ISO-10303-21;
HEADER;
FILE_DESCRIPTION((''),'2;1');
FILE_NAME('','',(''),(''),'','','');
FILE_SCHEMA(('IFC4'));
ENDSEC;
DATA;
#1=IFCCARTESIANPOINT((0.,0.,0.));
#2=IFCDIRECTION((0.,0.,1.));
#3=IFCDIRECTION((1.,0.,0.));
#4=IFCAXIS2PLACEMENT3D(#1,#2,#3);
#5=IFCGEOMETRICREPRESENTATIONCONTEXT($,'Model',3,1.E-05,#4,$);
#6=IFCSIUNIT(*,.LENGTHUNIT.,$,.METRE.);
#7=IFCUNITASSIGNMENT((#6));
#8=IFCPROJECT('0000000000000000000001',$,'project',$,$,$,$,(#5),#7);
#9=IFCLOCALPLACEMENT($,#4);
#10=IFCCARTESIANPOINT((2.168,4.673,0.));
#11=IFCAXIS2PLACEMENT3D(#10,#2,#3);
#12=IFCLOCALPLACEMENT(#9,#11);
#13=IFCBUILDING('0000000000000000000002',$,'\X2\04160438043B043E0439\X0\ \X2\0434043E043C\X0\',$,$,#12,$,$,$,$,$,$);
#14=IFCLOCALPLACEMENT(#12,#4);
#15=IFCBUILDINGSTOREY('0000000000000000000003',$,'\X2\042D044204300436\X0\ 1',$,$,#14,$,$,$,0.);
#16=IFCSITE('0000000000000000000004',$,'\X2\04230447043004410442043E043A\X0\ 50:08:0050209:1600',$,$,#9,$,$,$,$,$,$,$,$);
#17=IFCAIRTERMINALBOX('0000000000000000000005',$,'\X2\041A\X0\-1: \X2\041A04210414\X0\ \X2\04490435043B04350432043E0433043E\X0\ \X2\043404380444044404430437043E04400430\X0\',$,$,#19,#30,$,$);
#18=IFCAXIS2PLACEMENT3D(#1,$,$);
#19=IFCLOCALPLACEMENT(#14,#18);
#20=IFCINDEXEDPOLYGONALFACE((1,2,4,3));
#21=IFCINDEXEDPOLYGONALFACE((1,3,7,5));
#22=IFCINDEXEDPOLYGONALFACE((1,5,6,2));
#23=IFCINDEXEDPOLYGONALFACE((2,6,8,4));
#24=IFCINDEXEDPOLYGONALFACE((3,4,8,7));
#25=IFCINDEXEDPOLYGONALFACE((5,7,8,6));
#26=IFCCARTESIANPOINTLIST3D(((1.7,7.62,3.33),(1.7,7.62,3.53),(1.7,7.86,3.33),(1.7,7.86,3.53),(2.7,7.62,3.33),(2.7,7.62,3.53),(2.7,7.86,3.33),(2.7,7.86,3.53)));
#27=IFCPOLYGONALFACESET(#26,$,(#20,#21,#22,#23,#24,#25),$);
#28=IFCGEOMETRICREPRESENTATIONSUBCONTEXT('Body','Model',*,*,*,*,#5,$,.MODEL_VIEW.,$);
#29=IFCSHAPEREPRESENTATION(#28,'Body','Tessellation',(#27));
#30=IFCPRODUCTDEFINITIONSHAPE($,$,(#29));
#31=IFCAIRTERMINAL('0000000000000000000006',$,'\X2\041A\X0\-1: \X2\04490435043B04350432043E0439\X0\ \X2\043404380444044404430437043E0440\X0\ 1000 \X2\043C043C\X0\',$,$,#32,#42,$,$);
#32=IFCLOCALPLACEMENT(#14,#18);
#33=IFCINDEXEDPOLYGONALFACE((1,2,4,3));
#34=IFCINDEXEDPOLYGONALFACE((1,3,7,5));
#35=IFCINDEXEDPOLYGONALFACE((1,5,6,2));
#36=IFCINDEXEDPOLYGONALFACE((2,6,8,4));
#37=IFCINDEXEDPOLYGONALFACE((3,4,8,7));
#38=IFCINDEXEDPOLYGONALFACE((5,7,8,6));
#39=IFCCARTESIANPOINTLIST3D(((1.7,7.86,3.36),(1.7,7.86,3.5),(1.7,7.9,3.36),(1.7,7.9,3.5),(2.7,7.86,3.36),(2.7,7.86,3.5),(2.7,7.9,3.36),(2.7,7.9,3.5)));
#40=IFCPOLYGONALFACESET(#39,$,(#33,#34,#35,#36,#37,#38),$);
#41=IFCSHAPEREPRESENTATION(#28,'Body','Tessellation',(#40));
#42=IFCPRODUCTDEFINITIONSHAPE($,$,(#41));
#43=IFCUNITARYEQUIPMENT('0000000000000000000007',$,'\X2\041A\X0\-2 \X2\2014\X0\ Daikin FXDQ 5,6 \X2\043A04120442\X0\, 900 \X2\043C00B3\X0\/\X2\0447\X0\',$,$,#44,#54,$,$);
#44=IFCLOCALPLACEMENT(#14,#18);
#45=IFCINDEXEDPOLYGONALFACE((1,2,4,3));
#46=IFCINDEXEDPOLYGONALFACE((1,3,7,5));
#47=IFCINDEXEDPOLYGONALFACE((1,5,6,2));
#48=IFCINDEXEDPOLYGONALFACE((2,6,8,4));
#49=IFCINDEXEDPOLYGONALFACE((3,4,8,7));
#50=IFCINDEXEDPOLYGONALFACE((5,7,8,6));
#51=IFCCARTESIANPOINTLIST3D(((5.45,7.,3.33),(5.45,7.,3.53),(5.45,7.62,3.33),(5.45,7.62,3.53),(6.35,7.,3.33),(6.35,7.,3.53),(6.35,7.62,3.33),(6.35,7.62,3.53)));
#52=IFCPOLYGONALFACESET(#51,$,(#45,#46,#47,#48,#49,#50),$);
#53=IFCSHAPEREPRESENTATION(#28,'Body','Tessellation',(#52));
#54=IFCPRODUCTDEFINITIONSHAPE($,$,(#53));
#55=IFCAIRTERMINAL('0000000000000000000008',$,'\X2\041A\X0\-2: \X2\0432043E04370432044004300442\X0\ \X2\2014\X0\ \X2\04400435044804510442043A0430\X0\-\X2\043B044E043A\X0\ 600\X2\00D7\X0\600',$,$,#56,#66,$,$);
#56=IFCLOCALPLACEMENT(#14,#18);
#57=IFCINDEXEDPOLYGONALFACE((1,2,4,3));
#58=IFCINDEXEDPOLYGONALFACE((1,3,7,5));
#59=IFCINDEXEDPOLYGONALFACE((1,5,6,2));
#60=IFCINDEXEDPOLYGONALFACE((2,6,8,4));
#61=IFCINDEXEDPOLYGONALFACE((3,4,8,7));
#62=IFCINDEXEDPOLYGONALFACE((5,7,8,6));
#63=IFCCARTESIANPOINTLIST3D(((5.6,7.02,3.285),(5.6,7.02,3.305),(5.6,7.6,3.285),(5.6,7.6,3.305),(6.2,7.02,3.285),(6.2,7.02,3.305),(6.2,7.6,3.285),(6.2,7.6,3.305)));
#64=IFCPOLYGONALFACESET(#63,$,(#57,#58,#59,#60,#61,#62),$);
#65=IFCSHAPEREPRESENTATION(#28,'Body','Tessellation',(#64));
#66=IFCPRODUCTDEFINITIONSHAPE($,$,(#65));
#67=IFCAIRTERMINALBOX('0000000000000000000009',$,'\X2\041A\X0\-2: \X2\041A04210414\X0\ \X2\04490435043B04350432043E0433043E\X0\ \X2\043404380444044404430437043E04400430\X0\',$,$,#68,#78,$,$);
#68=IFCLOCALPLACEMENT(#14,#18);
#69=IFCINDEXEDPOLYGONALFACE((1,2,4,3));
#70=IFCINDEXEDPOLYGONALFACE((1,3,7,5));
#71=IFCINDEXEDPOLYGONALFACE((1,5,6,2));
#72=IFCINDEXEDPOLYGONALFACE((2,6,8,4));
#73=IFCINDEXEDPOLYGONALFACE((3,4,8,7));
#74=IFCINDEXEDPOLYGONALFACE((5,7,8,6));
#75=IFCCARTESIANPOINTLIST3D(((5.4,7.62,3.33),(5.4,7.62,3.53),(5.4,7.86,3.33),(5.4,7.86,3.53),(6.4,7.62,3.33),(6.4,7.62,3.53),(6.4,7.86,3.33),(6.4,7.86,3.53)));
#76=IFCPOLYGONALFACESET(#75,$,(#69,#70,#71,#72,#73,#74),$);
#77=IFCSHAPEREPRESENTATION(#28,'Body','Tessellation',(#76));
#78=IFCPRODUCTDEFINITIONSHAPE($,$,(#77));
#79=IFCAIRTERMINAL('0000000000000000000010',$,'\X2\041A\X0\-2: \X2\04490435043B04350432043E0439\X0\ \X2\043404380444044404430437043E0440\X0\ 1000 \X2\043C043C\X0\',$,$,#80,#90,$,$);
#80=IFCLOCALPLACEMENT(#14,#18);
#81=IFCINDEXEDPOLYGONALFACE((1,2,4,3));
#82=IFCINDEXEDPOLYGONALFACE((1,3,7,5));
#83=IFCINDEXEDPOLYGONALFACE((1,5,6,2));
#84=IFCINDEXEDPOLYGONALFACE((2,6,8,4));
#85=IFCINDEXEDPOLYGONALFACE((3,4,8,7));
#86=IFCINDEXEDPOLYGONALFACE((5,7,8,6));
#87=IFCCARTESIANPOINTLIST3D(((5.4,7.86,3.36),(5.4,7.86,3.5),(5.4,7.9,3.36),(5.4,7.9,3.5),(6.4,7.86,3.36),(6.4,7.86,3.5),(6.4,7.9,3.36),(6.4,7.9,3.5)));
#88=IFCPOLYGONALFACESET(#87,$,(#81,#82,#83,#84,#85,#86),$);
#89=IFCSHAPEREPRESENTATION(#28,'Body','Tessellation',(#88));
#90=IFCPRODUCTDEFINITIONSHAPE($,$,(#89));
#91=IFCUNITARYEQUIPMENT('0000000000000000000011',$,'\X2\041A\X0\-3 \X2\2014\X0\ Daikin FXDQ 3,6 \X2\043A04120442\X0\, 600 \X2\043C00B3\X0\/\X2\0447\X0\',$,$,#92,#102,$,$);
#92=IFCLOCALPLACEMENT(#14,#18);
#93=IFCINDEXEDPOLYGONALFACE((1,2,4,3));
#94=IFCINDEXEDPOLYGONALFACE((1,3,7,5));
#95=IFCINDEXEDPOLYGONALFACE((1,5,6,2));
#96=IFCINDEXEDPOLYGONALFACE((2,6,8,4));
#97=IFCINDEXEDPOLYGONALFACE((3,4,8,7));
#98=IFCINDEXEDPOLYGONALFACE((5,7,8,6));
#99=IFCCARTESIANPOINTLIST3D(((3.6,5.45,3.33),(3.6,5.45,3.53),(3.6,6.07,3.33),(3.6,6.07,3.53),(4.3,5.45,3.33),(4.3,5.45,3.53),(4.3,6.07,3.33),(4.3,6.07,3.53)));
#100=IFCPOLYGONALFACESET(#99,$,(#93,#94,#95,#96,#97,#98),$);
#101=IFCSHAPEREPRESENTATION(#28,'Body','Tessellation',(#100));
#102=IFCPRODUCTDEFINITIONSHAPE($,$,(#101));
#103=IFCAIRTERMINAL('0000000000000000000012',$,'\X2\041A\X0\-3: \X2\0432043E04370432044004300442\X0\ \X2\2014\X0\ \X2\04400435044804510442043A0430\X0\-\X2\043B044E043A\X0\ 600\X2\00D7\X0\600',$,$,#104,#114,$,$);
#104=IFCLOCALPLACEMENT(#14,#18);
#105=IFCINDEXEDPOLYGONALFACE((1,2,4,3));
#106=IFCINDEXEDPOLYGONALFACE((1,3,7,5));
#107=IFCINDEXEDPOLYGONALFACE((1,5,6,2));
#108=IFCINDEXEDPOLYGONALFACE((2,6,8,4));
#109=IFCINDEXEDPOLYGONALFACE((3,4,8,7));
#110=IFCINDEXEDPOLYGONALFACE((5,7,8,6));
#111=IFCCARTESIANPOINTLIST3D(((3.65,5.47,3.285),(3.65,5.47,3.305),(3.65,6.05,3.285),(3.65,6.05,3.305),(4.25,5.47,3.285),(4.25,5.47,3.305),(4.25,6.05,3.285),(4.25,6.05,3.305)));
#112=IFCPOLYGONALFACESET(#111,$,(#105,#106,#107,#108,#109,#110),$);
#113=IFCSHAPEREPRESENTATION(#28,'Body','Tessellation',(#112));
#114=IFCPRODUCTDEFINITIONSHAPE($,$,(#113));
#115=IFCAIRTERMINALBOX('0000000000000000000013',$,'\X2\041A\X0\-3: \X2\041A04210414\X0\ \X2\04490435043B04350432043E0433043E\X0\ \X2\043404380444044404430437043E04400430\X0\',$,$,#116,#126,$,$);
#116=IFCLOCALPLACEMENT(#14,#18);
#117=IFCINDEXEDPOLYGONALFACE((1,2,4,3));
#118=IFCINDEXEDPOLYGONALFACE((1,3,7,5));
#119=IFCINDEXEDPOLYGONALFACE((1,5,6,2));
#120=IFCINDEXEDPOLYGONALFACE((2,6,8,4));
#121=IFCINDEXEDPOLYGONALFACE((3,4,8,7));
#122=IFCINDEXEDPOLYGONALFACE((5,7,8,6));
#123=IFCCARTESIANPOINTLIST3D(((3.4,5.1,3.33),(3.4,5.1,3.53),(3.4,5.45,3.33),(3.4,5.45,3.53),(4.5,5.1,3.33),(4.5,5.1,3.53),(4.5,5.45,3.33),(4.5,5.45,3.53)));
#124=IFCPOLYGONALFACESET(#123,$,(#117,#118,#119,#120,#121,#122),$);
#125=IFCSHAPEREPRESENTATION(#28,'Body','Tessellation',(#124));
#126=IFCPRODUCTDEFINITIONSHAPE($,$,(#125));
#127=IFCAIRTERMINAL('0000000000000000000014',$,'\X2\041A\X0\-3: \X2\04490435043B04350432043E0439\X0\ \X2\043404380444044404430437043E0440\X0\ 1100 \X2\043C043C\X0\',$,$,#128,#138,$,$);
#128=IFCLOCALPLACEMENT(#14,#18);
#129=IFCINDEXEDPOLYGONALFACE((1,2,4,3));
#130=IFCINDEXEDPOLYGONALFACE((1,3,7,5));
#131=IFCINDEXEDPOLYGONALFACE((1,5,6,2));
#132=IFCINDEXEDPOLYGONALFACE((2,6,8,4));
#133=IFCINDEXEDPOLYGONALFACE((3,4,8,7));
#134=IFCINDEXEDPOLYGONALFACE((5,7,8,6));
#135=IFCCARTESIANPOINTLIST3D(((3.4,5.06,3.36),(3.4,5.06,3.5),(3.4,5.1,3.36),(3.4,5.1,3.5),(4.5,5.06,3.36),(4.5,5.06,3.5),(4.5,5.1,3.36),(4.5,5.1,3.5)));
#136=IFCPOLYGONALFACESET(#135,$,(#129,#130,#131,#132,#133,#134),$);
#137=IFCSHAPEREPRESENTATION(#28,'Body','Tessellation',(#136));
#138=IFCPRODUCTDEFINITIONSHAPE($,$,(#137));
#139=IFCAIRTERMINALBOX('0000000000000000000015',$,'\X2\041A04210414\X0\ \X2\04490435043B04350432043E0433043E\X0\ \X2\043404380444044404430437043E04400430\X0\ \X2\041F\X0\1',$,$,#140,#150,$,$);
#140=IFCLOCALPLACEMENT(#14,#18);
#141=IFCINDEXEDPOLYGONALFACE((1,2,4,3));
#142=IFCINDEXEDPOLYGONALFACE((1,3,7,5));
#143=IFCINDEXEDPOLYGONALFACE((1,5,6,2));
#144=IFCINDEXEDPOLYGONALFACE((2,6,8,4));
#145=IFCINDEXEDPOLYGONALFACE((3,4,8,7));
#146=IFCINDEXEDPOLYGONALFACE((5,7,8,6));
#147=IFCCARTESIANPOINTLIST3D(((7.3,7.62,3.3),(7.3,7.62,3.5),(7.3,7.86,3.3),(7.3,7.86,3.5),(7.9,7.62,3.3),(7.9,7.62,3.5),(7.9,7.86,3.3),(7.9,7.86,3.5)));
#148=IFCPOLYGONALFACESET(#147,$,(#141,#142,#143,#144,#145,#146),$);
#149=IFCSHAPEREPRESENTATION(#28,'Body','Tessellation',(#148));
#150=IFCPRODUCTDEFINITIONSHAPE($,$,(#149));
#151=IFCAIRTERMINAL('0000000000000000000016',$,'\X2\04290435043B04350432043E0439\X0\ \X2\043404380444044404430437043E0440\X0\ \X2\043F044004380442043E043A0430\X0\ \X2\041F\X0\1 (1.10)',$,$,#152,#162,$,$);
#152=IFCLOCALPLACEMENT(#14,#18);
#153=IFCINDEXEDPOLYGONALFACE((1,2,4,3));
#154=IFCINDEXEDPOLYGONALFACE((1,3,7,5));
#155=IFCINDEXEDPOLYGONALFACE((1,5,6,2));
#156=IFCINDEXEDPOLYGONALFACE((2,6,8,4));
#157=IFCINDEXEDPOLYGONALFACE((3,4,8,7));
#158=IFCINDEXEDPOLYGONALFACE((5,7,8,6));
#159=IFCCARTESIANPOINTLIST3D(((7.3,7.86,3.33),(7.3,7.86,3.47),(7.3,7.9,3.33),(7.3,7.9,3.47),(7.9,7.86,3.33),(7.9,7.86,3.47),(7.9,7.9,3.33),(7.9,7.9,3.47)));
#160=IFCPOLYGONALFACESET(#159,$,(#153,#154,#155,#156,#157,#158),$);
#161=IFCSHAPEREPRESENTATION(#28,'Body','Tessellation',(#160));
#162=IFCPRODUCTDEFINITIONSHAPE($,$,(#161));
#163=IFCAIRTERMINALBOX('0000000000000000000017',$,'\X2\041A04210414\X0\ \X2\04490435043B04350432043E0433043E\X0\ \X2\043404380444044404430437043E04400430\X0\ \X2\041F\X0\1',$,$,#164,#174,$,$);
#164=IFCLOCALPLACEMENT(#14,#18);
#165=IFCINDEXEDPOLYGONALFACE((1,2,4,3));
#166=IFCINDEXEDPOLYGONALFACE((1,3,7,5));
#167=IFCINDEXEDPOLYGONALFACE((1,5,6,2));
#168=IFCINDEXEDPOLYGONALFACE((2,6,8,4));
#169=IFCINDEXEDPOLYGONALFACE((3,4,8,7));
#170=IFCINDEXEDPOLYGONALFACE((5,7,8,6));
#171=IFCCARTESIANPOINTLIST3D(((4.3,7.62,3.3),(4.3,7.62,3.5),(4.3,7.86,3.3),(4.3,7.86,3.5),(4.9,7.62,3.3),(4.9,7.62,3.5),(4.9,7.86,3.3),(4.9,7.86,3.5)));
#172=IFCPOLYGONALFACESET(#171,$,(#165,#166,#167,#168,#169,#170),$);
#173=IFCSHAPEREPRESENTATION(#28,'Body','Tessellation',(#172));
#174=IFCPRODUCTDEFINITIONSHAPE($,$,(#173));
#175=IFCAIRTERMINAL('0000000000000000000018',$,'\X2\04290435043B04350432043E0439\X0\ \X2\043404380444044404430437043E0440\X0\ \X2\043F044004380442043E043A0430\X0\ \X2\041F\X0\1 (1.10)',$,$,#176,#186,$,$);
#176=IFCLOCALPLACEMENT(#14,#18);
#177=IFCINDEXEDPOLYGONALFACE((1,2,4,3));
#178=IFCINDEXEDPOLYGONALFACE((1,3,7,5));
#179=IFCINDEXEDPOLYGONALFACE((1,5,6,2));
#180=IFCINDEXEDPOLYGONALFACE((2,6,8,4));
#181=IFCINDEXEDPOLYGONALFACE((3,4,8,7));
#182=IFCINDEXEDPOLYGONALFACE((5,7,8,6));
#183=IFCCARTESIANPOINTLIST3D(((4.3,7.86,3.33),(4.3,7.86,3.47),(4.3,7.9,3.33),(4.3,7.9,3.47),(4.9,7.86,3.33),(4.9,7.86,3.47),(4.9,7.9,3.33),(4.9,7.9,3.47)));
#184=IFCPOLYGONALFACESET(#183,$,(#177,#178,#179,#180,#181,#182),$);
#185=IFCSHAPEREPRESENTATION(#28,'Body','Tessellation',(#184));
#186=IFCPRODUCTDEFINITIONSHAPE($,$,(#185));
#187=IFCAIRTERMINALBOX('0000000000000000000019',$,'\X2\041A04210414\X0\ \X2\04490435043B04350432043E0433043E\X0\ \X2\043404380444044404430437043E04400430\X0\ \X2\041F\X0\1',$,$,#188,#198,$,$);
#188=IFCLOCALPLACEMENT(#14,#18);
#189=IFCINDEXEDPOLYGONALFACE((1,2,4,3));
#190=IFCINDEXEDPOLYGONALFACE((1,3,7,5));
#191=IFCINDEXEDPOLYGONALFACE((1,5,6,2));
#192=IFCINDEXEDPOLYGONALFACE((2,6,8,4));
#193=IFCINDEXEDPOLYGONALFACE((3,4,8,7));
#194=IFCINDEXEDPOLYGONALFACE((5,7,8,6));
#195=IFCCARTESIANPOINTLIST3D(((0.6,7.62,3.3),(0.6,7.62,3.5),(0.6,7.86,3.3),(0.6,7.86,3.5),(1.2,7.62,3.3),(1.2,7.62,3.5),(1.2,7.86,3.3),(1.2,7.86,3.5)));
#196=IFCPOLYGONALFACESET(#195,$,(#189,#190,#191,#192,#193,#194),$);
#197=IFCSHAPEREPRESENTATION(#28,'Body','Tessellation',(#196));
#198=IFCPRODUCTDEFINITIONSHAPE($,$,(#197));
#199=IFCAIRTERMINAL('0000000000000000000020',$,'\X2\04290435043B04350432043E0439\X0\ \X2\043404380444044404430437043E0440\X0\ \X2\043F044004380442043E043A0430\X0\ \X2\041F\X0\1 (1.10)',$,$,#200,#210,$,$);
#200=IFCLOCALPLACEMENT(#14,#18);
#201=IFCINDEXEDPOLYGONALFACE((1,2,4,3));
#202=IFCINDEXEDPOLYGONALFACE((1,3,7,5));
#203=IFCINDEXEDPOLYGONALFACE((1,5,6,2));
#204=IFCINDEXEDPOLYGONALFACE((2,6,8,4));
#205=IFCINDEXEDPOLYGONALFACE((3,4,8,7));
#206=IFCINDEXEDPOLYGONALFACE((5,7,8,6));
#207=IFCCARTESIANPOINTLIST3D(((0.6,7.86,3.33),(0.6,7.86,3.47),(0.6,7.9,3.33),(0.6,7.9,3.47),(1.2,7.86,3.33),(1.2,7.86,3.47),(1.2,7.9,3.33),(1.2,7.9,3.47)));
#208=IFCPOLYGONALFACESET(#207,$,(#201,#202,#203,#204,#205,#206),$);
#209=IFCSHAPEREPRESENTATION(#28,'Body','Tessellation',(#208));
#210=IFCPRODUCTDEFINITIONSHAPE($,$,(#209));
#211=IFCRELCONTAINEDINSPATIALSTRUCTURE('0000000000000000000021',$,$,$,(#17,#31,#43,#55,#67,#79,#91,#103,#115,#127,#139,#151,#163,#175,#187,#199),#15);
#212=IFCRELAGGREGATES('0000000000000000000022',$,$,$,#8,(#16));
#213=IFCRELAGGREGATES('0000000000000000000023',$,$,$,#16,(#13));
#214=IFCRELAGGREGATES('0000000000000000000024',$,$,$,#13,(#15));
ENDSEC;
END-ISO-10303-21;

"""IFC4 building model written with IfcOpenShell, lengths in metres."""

from ifc_helpers import new_model, si_unit, frame, frame_2d, origin_with_axes, place, context, subcontext, project, spatial, rectangle, extrude, element, save


model = new_model("IFC4")

# Units and contexts
model_context = context("Model", 3, precision=1e-05, world=origin_with_axes())
body_context = subcontext(model_context, "Body", "Model", "MODEL_VIEW")
ifc_project = project(units=[si_unit("LENGTHUNIT", "METRE")], contexts=[model_context])

# Site, building, storey
site_placement = place(None, origin_with_axes())
site = spatial("IfcSite", under=ifc_project, at=site_placement, Name="Участок 50:08:0050209:1600")
building_placement = place(site_placement, frame((2.168, 4.673, 0.0), z_axis=(0.0, 0.0, 1.0), x_axis=(1.0, 0.0, 0.0)))
building = spatial("IfcBuilding", under=site, at=building_placement, Name="Жилой дом")
storey_placement = place(building_placement, origin_with_axes())
storey = spatial("IfcBuildingStorey", under=building, at=storey_placement, Name="Этаж 1", Elevation=0.0)

# Air terminal box
air_terminal_box_1_placement = place(storey_placement, origin_with_axes())
element("IfcAirTerminalBox", 1, at=air_terminal_box_1_placement, inside=storey, Name="К-1: КСД щелевого диффузора", context=body_context, shape_type="SweptSolid", body=[
    extrude(rectangle(XDim=1.0, YDim=0.24, at=frame_2d((0.5, 0.12))), frame((1.7, 7.62, 3.33), z_axis=(0.0, 0.0, 1.0), x_axis=(1.0, 0.0, 0.0)), (0.0, 0.0, 1.0), 0.2),
])

# Air terminal
air_terminal_1_placement = place(storey_placement, origin_with_axes())
element("IfcAirTerminal", 2, at=air_terminal_1_placement, inside=storey, Name="К-1: щелевой диффузор 1000 мм", context=body_context, shape_type="SweptSolid", body=[
    extrude(rectangle(XDim=1.0, YDim=0.04, at=frame_2d((0.5, 0.02))), frame((1.7, 7.86, 3.36), z_axis=(0.0, 0.0, 1.0), x_axis=(1.0, 0.0, 0.0)), (0.0, 0.0, 1.0), 0.14),
])

# Unitary equipment
unitary_equipment_1_placement = place(storey_placement, origin_with_axes())
element("IfcUnitaryEquipment", 3, at=unitary_equipment_1_placement, inside=storey, Name="К-2 — Daikin FXDQ 5,6 кВт, 900 м³/ч", context=body_context, shape_type="SweptSolid", body=[
    extrude(rectangle(XDim=0.9, YDim=0.62, at=frame_2d((0.45, 0.31))), frame((5.45, 7.0, 3.33), z_axis=(0.0, 0.0, 1.0), x_axis=(1.0, 0.0, 0.0)), (0.0, 0.0, 1.0), 0.2),
])

# Air terminal
air_terminal_2_placement = place(storey_placement, origin_with_axes())
element("IfcAirTerminal", 4, at=air_terminal_2_placement, inside=storey, Name="К-2: возврат — решётка-люк 600×600", context=body_context, shape_type="SweptSolid", body=[
    extrude(rectangle(XDim=0.6, YDim=0.58, at=frame_2d((0.3, 0.29))), frame((5.6, 7.02, 3.285), z_axis=(0.0, 0.0, 1.0), x_axis=(1.0, 0.0, 0.0)), (0.0, 0.0, 1.0), 0.02),
])

# Air terminal box
air_terminal_box_2_placement = place(storey_placement, origin_with_axes())
element("IfcAirTerminalBox", 5, at=air_terminal_box_2_placement, inside=storey, Name="К-2: КСД щелевого диффузора", context=body_context, shape_type="SweptSolid", body=[
    extrude(rectangle(XDim=1.0, YDim=0.24, at=frame_2d((0.5, 0.12))), frame((5.4, 7.62, 3.33), z_axis=(0.0, 0.0, 1.0), x_axis=(1.0, 0.0, 0.0)), (0.0, 0.0, 1.0), 0.2),
])

# Air terminal
air_terminal_3_placement = place(storey_placement, origin_with_axes())
element("IfcAirTerminal", 6, at=air_terminal_3_placement, inside=storey, Name="К-2: щелевой диффузор 1000 мм", context=body_context, shape_type="SweptSolid", body=[
    extrude(rectangle(XDim=1.0, YDim=0.04, at=frame_2d((0.5, 0.02))), frame((5.4, 7.86, 3.36), z_axis=(0.0, 0.0, 1.0), x_axis=(1.0, 0.0, 0.0)), (0.0, 0.0, 1.0), 0.14),
])

# Unitary equipment
unitary_equipment_2_placement = place(storey_placement, origin_with_axes())
element("IfcUnitaryEquipment", 7, at=unitary_equipment_2_placement, inside=storey, Name="К-3 — Daikin FXDQ 3,6 кВт, 600 м³/ч", context=body_context, shape_type="SweptSolid", body=[
    extrude(rectangle(XDim=0.7, YDim=0.62, at=frame_2d((0.35, 0.31))), frame((3.6, 5.45, 3.33), z_axis=(0.0, 0.0, 1.0), x_axis=(1.0, 0.0, 0.0)), (0.0, 0.0, 1.0), 0.2),
])

# Air terminal
air_terminal_4_placement = place(storey_placement, origin_with_axes())
element("IfcAirTerminal", 8, at=air_terminal_4_placement, inside=storey, Name="К-3: возврат — решётка-люк 600×600", context=body_context, shape_type="SweptSolid", body=[
    extrude(rectangle(XDim=0.6, YDim=0.58, at=frame_2d((0.3, 0.29))), frame((3.65, 5.47, 3.285), z_axis=(0.0, 0.0, 1.0), x_axis=(1.0, 0.0, 0.0)), (0.0, 0.0, 1.0), 0.02),
])

# Air terminal box
air_terminal_box_3_placement = place(storey_placement, origin_with_axes())
element("IfcAirTerminalBox", 9, at=air_terminal_box_3_placement, inside=storey, Name="К-3: КСД щелевого диффузора", context=body_context, shape_type="SweptSolid", body=[
    extrude(rectangle(XDim=1.1, YDim=0.35, at=frame_2d((0.55, 0.175))), frame((3.4, 5.1, 3.33), z_axis=(0.0, 0.0, 1.0), x_axis=(1.0, 0.0, 0.0)), (0.0, 0.0, 1.0), 0.2),
])

# Air terminal
air_terminal_5_placement = place(storey_placement, origin_with_axes())
element("IfcAirTerminal", 10, at=air_terminal_5_placement, inside=storey, Name="К-3: щелевой диффузор 1100 мм", context=body_context, shape_type="SweptSolid", body=[
    extrude(rectangle(XDim=1.1, YDim=0.04, at=frame_2d((0.55, 0.02))), frame((3.4, 5.06, 3.36), z_axis=(0.0, 0.0, 1.0), x_axis=(1.0, 0.0, 0.0)), (0.0, 0.0, 1.0), 0.14),
])

# Air terminal box
air_terminal_box_4_placement = place(storey_placement, origin_with_axes())
element("IfcAirTerminalBox", 11, at=air_terminal_box_4_placement, inside=storey, Name="КСД щелевого диффузора П1", context=body_context, shape_type="SweptSolid", body=[
    extrude(rectangle(XDim=0.6, YDim=0.24, at=frame_2d((0.3, 0.12))), frame((7.3, 7.62, 3.3), z_axis=(0.0, 0.0, 1.0), x_axis=(1.0, 0.0, 0.0)), (0.0, 0.0, 1.0), 0.2),
])

# Air terminal
air_terminal_6_placement = place(storey_placement, origin_with_axes())
element("IfcAirTerminal", 12, at=air_terminal_6_placement, inside=storey, Name="Щелевой диффузор притока П1 (1.10)", context=body_context, shape_type="SweptSolid", body=[
    extrude(rectangle(XDim=0.6, YDim=0.04, at=frame_2d((0.3, 0.02))), frame((7.3, 7.86, 3.33), z_axis=(0.0, 0.0, 1.0), x_axis=(1.0, 0.0, 0.0)), (0.0, 0.0, 1.0), 0.14),
])

# Air terminal box
air_terminal_box_5_placement = place(storey_placement, origin_with_axes())
element("IfcAirTerminalBox", 13, at=air_terminal_box_5_placement, inside=storey, Name="КСД щелевого диффузора П1", context=body_context, shape_type="SweptSolid", body=[
    extrude(rectangle(XDim=0.6, YDim=0.24, at=frame_2d((0.3, 0.12))), frame((4.3, 7.62, 3.3), z_axis=(0.0, 0.0, 1.0), x_axis=(1.0, 0.0, 0.0)), (0.0, 0.0, 1.0), 0.2),
])

# Air terminal
air_terminal_7_placement = place(storey_placement, origin_with_axes())
element("IfcAirTerminal", 14, at=air_terminal_7_placement, inside=storey, Name="Щелевой диффузор притока П1 (1.10)", context=body_context, shape_type="SweptSolid", body=[
    extrude(rectangle(XDim=0.6, YDim=0.04, at=frame_2d((0.3, 0.02))), frame((4.3, 7.86, 3.33), z_axis=(0.0, 0.0, 1.0), x_axis=(1.0, 0.0, 0.0)), (0.0, 0.0, 1.0), 0.14),
])

# Air terminal box
air_terminal_box_6_placement = place(storey_placement, origin_with_axes())
element("IfcAirTerminalBox", 15, at=air_terminal_box_6_placement, inside=storey, Name="КСД щелевого диффузора П1", context=body_context, shape_type="SweptSolid", body=[
    extrude(rectangle(XDim=0.6, YDim=0.24, at=frame_2d((0.3, 0.12))), frame((0.6, 7.62, 3.3), z_axis=(0.0, 0.0, 1.0), x_axis=(1.0, 0.0, 0.0)), (0.0, 0.0, 1.0), 0.2),
])

# Air terminal
air_terminal_8_placement = place(storey_placement, origin_with_axes())
element("IfcAirTerminal", 16, at=air_terminal_8_placement, inside=storey, Name="Щелевой диффузор притока П1 (1.10)", context=body_context, shape_type="SweptSolid", body=[
    extrude(rectangle(XDim=0.6, YDim=0.04, at=frame_2d((0.3, 0.02))), frame((0.6, 7.86, 3.33), z_axis=(0.0, 0.0, 1.0), x_axis=(1.0, 0.0, 0.0)), (0.0, 0.0, 1.0), 0.14),
])

save(model, "model.ifc")
